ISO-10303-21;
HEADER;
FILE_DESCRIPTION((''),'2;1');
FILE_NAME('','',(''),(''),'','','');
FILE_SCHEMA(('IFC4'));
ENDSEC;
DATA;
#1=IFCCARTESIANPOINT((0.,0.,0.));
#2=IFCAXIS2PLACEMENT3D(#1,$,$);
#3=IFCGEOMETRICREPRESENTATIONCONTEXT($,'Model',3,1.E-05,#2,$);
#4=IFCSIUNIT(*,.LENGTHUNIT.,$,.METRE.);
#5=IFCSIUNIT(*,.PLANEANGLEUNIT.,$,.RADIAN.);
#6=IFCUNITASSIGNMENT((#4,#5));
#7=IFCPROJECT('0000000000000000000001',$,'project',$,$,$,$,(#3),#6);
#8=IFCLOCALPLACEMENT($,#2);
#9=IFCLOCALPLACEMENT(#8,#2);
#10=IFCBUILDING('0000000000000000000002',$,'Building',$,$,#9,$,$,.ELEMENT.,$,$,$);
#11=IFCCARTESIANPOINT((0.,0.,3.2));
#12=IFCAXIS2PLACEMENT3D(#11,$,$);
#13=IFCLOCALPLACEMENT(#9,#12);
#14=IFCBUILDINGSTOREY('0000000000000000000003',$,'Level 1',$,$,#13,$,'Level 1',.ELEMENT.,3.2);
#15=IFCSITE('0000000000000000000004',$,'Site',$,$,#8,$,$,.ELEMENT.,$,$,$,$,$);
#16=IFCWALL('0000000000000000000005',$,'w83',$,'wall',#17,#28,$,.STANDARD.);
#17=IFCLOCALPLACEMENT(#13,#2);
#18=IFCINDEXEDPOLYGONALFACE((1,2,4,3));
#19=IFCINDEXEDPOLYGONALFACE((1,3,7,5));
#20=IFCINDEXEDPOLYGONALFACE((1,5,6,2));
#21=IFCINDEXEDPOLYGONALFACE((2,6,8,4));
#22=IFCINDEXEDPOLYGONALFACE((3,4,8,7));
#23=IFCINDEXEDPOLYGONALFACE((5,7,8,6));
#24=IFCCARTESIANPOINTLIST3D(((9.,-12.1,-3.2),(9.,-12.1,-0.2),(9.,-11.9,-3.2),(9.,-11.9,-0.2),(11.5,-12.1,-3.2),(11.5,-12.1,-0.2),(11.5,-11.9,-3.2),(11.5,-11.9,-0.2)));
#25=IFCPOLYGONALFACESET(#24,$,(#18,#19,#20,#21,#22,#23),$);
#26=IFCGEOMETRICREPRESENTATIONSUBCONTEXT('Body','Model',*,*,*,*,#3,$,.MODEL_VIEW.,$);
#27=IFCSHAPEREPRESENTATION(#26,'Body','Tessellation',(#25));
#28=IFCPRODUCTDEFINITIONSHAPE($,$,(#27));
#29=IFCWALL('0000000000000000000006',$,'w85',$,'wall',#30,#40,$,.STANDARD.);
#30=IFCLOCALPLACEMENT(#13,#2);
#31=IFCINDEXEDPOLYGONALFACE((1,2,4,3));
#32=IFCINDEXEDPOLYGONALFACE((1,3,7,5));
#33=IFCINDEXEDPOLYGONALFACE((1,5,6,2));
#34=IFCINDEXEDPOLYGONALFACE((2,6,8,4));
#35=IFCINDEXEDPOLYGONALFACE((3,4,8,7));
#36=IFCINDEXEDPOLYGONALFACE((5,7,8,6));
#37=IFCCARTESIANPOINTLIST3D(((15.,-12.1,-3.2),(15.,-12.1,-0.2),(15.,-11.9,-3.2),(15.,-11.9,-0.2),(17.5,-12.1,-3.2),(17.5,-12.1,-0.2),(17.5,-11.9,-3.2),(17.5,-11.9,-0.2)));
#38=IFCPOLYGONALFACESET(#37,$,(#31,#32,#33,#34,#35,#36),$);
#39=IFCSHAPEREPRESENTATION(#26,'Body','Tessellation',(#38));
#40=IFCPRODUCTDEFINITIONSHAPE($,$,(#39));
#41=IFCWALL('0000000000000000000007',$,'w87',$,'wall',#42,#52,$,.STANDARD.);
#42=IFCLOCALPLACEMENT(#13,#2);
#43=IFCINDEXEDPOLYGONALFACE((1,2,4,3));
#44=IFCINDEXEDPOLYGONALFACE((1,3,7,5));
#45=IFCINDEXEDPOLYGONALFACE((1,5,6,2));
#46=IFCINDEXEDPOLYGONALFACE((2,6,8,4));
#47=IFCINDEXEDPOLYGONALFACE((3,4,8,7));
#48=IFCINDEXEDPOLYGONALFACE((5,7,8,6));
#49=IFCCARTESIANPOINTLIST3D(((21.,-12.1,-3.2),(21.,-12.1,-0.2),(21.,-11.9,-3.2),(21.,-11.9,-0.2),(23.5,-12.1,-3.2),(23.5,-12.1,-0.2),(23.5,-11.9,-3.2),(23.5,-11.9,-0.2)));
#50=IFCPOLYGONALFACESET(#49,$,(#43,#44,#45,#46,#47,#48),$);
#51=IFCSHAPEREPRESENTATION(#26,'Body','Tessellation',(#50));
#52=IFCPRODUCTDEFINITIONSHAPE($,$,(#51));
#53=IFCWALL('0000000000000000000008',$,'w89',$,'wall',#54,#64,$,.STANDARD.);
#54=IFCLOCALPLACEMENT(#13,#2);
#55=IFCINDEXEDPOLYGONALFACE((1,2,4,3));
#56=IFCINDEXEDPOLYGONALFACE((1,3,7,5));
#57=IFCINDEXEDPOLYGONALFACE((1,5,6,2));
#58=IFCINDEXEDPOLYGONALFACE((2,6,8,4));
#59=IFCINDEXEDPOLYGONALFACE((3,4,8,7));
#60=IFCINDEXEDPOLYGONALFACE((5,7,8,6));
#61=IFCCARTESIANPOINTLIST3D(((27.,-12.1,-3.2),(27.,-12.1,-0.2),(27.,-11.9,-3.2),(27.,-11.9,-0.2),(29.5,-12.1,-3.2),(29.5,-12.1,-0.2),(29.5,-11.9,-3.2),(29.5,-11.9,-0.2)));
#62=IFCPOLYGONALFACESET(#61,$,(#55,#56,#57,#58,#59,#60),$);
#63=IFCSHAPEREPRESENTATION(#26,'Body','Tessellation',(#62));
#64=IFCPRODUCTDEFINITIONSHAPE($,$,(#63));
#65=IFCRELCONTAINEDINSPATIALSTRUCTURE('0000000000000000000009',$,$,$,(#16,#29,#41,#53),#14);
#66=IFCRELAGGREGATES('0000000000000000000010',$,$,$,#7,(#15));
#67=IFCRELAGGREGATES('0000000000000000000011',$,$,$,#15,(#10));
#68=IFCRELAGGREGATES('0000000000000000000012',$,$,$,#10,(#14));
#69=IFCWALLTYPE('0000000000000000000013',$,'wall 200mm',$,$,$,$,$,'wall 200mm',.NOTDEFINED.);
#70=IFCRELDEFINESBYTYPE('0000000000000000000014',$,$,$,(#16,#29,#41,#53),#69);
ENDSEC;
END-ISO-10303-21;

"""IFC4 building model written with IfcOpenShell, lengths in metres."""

from ifc_helpers import new_model, si_unit, frame, frame_2d, origin, place, context, subcontext, project, spatial, rectangle, extrude, type_object, element, save


model = new_model("IFC4")

# Units and contexts
model_context = context("Model", 3, precision=1e-05, world=origin())
body_context = subcontext(model_context, "Body", "Model", "MODEL_VIEW")
ifc_project = project(units=[si_unit("LENGTHUNIT", "METRE"), si_unit("PLANEANGLEUNIT", "RADIAN")], contexts=[model_context])

# Site, building, storey
site_placement = place(None, origin())
site = spatial("IfcSite", under=ifc_project, at=site_placement, Name="Site", CompositionType="ELEMENT")
building_placement = place(site_placement, origin())
building = spatial("IfcBuilding", under=site, at=building_placement, Name="Building", CompositionType="ELEMENT")
storey_placement = place(building_placement, frame((0.0, 0.0, 3.2)))
storey = spatial("IfcBuildingStorey", under=building, at=storey_placement, Name="Level 1", LongName="Level 1", CompositionType="ELEMENT", Elevation=3.2)

# Walls
wall_type = type_object("IfcWallType", Name="wall 200mm", ElementType="wall 200mm", PredefinedType="NOTDEFINED")
for number, where, z_axis, x_axis, name in (
    (1, (9.0, -12.0, -3.2), (0.0, 0.0, 1.0), (1.0, 0.0, 0.0), "w83"),
    (2, (15.0, -12.0, -3.2), (0.0, 0.0, 1.0), (1.0, 0.0, 0.0), "w85"),
    (3, (21.0, -12.0, -3.2), (0.0, 0.0, 1.0), (1.0, 0.0, 0.0), "w87"),
    (4, (27.0, -12.0, -3.2), (0.0, 0.0, 1.0), (1.0, 0.0, 0.0), "w89"),
):
    element("IfcWall", number, at=place(storey_placement, frame(where, z_axis=z_axis, x_axis=x_axis)), inside=storey, type_object=wall_type, Name=name, ObjectType="wall", PredefinedType="STANDARD", context=body_context, shape_type="SweptSolid", body=[
        extrude(rectangle(XDim=2.5, YDim=0.2, at=frame_2d((1.25, 0.0))), origin(), (0.0, 0.0, 1.0), 3.0),
    ])

save(model, "model.ifc")
